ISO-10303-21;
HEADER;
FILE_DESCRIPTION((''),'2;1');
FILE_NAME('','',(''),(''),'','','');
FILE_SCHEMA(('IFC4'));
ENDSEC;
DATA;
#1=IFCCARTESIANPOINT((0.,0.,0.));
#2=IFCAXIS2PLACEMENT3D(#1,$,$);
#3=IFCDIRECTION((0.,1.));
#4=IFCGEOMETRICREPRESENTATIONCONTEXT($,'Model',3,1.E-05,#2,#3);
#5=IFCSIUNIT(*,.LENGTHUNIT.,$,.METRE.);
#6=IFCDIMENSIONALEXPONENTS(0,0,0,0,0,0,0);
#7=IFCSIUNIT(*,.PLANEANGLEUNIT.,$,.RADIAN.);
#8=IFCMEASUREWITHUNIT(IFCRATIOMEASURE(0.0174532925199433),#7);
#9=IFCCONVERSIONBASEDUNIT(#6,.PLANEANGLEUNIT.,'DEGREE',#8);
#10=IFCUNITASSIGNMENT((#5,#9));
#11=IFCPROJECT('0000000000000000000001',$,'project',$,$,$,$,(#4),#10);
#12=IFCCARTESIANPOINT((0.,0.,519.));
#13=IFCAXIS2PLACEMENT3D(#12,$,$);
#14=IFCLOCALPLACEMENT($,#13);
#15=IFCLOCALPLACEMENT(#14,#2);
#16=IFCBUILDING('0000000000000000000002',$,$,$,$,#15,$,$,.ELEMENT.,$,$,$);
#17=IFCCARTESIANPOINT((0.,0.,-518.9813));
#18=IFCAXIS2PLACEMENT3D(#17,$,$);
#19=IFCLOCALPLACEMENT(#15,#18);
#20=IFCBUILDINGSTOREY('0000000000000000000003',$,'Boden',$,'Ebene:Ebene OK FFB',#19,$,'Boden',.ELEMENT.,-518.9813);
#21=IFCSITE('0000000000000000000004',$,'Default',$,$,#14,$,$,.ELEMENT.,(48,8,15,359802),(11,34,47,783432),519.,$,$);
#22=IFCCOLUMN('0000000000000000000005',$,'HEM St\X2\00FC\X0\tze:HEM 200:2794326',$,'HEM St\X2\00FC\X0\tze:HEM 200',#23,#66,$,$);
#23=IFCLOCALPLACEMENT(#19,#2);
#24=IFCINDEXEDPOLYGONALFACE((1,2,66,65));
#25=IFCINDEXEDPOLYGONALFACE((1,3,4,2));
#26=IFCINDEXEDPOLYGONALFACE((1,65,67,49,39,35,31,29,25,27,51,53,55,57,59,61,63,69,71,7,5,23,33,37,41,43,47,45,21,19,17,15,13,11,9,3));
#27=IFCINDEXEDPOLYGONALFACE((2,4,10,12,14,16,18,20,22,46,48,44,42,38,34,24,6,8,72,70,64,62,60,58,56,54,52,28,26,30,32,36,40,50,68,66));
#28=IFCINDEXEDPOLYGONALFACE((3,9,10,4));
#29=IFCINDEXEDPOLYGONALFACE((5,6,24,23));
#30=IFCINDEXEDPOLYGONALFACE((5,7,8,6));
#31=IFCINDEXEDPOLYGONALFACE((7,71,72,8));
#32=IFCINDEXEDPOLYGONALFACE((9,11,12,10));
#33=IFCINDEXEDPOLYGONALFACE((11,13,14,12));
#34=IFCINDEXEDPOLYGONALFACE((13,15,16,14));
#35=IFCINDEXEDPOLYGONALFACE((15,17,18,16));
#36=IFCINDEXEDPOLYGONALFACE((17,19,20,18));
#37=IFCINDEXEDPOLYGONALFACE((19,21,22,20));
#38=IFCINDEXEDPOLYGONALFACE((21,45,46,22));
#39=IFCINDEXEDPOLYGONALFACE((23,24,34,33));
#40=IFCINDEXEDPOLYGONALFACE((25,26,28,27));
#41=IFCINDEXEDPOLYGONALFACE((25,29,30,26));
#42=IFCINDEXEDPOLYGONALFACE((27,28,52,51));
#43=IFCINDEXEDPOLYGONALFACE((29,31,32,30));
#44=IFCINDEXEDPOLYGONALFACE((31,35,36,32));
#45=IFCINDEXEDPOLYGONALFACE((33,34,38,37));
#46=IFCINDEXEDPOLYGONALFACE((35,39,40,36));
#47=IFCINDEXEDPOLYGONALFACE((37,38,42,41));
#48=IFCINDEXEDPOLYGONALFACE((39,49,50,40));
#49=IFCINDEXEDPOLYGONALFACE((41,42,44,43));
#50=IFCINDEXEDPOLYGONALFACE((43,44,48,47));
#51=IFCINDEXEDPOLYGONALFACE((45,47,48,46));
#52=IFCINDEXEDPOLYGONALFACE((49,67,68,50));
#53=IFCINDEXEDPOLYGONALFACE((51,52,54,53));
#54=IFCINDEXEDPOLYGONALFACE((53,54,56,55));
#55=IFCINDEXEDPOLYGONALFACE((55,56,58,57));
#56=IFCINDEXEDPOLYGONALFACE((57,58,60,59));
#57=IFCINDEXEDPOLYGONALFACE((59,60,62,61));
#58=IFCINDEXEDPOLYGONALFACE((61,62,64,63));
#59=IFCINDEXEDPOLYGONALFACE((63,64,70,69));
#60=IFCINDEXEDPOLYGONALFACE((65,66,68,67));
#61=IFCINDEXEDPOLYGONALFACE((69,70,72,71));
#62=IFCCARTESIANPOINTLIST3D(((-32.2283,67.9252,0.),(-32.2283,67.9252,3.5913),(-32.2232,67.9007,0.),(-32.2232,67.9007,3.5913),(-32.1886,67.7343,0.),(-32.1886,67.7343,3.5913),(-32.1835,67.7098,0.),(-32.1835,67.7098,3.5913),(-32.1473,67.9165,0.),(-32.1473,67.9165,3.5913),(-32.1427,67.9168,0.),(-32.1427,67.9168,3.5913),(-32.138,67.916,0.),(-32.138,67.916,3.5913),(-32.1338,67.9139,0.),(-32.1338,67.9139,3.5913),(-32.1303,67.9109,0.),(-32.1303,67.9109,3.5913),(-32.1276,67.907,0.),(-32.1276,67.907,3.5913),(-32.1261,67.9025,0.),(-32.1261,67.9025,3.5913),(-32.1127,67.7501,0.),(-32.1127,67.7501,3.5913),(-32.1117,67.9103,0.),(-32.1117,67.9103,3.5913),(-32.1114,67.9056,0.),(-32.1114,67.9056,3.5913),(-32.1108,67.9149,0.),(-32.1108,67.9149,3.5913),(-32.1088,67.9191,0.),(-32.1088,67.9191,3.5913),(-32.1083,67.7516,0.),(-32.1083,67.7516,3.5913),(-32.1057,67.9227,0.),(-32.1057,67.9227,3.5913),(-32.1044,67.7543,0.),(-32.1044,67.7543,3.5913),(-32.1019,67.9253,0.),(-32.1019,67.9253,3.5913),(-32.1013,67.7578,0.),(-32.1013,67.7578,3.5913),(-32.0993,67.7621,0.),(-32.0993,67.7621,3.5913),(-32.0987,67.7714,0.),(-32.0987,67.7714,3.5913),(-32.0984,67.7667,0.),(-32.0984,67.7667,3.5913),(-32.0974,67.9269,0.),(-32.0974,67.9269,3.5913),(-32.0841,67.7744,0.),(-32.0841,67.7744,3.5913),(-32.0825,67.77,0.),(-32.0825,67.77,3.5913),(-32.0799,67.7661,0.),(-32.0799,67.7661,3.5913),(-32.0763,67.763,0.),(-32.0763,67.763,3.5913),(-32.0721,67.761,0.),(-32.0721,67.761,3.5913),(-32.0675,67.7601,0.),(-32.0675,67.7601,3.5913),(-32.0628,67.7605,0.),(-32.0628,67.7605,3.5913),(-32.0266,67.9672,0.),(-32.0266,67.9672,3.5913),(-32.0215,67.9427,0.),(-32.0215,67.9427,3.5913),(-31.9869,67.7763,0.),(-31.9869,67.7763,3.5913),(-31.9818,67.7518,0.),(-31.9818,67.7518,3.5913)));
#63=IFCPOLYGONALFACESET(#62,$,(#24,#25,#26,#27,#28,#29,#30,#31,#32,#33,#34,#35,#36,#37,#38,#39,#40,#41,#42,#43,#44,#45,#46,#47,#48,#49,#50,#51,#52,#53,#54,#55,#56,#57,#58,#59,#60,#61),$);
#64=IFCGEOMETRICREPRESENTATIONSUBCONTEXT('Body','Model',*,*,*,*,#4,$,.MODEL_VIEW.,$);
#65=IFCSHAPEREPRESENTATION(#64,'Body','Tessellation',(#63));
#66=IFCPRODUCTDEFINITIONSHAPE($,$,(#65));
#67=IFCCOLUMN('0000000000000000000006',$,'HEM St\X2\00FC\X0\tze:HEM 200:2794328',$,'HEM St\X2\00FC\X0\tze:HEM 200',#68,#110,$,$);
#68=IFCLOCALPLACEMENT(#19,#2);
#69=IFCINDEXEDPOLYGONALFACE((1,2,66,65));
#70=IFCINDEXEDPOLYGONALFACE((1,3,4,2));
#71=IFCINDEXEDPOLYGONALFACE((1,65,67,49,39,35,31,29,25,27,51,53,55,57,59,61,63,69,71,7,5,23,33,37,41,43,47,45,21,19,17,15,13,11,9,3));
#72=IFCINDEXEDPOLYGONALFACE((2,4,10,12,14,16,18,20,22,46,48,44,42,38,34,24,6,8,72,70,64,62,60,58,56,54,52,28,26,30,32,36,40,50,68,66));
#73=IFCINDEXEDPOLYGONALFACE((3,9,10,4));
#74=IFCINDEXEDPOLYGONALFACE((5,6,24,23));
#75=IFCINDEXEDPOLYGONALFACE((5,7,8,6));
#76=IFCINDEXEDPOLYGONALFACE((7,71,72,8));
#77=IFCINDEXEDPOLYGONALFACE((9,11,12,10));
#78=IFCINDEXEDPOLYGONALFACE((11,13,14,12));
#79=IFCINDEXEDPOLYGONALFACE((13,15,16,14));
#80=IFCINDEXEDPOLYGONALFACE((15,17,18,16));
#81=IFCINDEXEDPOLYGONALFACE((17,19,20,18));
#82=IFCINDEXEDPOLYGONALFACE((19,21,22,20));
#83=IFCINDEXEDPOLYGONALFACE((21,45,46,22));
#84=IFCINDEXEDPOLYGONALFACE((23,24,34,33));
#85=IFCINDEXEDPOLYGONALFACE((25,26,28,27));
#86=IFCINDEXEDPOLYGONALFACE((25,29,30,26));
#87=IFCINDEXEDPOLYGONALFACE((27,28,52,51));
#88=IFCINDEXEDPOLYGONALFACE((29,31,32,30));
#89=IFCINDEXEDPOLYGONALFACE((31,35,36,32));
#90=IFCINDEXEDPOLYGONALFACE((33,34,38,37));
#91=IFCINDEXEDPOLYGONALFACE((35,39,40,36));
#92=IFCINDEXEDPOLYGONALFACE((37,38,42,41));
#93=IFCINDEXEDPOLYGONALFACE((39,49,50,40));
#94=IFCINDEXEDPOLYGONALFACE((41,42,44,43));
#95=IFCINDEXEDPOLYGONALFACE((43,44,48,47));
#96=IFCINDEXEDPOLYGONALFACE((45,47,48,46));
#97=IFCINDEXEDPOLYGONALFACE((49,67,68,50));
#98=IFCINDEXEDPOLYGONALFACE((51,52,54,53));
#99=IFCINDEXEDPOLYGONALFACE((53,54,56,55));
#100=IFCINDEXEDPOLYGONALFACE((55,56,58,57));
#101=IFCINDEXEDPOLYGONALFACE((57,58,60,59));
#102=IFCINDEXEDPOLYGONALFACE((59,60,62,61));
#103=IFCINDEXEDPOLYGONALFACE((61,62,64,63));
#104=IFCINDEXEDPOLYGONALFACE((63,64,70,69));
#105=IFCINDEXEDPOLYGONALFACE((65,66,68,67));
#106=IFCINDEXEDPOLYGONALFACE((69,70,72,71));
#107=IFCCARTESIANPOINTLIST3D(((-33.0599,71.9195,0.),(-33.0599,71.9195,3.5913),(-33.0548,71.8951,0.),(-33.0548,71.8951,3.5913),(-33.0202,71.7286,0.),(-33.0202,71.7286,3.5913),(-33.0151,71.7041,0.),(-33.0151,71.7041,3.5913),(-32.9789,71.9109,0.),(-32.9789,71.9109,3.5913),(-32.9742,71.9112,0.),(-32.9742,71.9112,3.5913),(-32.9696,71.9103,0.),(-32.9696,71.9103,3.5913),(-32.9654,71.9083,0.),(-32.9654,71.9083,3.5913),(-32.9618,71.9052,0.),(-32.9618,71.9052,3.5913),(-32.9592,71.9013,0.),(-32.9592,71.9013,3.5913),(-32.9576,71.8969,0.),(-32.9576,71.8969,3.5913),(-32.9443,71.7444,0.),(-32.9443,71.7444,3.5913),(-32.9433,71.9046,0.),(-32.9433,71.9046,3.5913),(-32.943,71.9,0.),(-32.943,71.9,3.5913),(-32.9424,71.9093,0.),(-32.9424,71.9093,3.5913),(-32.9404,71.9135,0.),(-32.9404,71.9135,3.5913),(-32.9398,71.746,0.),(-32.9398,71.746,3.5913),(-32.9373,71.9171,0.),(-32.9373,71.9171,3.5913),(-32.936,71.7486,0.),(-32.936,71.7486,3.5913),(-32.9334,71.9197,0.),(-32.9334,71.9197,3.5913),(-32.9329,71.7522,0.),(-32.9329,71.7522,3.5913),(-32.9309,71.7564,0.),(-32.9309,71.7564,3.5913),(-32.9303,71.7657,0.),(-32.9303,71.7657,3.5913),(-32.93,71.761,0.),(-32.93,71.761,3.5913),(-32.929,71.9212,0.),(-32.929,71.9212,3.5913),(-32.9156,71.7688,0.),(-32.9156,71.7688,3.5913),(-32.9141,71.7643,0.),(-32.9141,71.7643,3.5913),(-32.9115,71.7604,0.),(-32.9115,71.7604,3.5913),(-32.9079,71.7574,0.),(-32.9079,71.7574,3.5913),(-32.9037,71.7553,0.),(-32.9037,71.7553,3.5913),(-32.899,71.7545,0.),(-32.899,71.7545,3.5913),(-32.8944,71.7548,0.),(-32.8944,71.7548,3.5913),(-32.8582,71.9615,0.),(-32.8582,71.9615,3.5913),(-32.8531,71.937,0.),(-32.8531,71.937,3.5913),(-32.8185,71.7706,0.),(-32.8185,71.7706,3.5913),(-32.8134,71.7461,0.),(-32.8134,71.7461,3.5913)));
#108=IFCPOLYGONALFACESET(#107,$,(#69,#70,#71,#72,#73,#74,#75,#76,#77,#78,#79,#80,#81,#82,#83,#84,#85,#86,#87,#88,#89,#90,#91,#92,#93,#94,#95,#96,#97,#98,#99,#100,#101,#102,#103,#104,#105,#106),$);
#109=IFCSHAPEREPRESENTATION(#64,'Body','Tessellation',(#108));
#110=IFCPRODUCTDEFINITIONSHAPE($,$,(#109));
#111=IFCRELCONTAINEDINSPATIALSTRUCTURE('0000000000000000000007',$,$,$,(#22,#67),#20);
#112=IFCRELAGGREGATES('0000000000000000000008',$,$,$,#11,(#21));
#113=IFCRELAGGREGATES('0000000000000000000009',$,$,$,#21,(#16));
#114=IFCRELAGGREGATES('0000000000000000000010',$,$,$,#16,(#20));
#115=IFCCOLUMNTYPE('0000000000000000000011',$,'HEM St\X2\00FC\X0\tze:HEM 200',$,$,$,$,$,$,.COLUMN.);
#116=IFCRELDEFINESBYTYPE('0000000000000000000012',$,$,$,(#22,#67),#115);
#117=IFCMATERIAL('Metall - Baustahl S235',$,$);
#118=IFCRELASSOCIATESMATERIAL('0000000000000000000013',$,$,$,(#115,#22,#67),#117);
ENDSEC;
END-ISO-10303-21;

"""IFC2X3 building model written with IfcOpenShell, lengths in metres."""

from ifc_helpers import new_model, entity, si_unit, converted_unit, direction, frame, frame_2d, origin, place, context, subcontext, project, spatial, polyline, circle_curve, parameter, trimmed, segment, composite_curve, outline, extrude, source, transform, mapped, material, type_object, type_shapes, element, save


model = new_model("IFC2X3")

# Units and contexts
model_context = context("Model", 3, precision=1e-05, world=origin(), true_north=direction((0.0, 1.0)))
body_context = subcontext(model_context, "Body", "Model", "MODEL_VIEW")
ifc_project = project(units=[si_unit("LENGTHUNIT", "METRE"), converted_unit("PLANEANGLEUNIT", "DEGREE", entity("IfcRatioMeasure", 0.0174532925199433), si_unit("PLANEANGLEUNIT", "RADIAN"), dimensions=[0, 0, 0, 0, 0, 0, 0])], contexts=[model_context])

# Site, building, storey
site_placement = place(None, frame((0.0, 0.0, 519.0)))
site = spatial("IfcSite", under=ifc_project, at=site_placement, Name="Default", CompositionType="ELEMENT", RefLatitude=(48, 8, 15, 359802), RefLongitude=(11, 34, 47, 783432), RefElevation=519.0)
building_placement = place(site_placement, origin())
building = spatial("IfcBuilding", under=site, at=building_placement, CompositionType="ELEMENT")
storey_placement = place(building_placement, frame((0.0, 0.0, -518.9813)))
storey = spatial("IfcBuildingStorey", under=building, at=storey_placement, Name="Boden", ObjectType="Ebene:Ebene OK FFB", LongName="Boden", CompositionType="ELEMENT", Elevation=-518.9813)

# Columns
ifc_material = material(Name="Metall - Baustahl S235")
column_type = type_object("IfcColumnType", Name="HEM Stütze:HEM 200", PredefinedType="COLUMN", material=ifc_material)
shared_shape = source(origin(), body_context, "Body", "SweptSolid", [
    extrude(outline(composite_curve([segment(polyline([(0.085, -0.103), (0.11, -0.103)]), True, "CONTINUOUS"), segment(polyline([(0.11, -0.103), (0.11, 0.103)]), True, "CONTINUOUS"), segment(polyline([(0.11, 0.103), (0.085, 0.103)]), True, "CONTINUOUS"), segment(polyline([(0.085, 0.103), (0.085, 0.0255)]), True, "CONTINUOUS"), segment(trimmed(circle_curve(frame_2d((0.067, 0.0255), x_axis=(1.0, 0.0)), 0.018), [parameter(270.0)], [parameter(0.0)], True, "PARAMETER"), False, "CONTINUOUS"), segment(polyline([(0.067, 0.0075), (-0.067, 0.0075)]), True, "CONTINUOUS"), segment(trimmed(circle_curve(frame_2d((-0.067, 0.0255), x_axis=(0.0, -1.0)), 0.018), [parameter(270.0)], [parameter(0.0)], True, "PARAMETER"), False, "CONTINUOUS"), segment(polyline([(-0.085, 0.0255), (-0.085, 0.103)]), True, "CONTINUOUS"), segment(polyline([(-0.085, 0.103), (-0.11, 0.103)]), True, "CONTINUOUS"), segment(polyline([(-0.11, 0.103), (-0.11, -0.103)]), True, "CONTINUOUS"), segment(polyline([(-0.11, -0.103), (-0.085, -0.103)]), True, "CONTINUOUS"), segment(polyline([(-0.085, -0.103), (-0.085, -0.0255)]), True, "CONTINUOUS"), segment(trimmed(circle_curve(frame_2d((-0.067, -0.0255), x_axis=(-1.0, 0.0)), 0.018), [parameter(270.0)], [parameter(0.0)], True, "PARAMETER"), False, "CONTINUOUS"), segment(polyline([(-0.067, -0.0075), (0.067, -0.0075)]), True, "CONTINUOUS"), segment(trimmed(circle_curve(frame_2d((0.067, -0.0255), x_axis=(0.0, 1.0)), 0.018), [parameter(270.0)], [parameter(0.0)], True, "PARAMETER"), False, "CONTINUOUS"), segment(polyline([(0.085, -0.0255), (0.085, -0.103)]), True, "CONTINUOUS")], self_intersect=False)), frame((0.0, 0.0, -518.9813), z_axis=(0.0, 0.0, 1.0), x_axis=(0.0, -1.0, 0.0)), (0.0, 0.0, 1.0), 3.5913),
])
type_shapes(column_type, [shared_shape])
for number, where, z_axis, x_axis, name in (
    (1, (-32.1051, 67.8385, 518.9813), (0.0, 0.0, 1.0), (0.979008, 0.20382, 0.0), "HEM Stütze:HEM 200:2794326"),
    (2, (-32.9366, 71.8328, 518.9813), (0.0, 0.0, 1.0), (0.979008, 0.20382, 0.0), "HEM Stütze:HEM 200:2794328"),
):
    element("IfcColumn", number, at=place(storey_placement, frame(where, z_axis=z_axis, x_axis=x_axis)), inside=storey, type_object=column_type, material=ifc_material, Name=name, ObjectType="HEM Stütze:HEM 200", context=body_context, shape_type="MappedRepresentation", body=[
        mapped(shared_shape, transform((0.0, 0.0, 0.0), scale=1.0)),
    ])

save(model, "model.ifc")
